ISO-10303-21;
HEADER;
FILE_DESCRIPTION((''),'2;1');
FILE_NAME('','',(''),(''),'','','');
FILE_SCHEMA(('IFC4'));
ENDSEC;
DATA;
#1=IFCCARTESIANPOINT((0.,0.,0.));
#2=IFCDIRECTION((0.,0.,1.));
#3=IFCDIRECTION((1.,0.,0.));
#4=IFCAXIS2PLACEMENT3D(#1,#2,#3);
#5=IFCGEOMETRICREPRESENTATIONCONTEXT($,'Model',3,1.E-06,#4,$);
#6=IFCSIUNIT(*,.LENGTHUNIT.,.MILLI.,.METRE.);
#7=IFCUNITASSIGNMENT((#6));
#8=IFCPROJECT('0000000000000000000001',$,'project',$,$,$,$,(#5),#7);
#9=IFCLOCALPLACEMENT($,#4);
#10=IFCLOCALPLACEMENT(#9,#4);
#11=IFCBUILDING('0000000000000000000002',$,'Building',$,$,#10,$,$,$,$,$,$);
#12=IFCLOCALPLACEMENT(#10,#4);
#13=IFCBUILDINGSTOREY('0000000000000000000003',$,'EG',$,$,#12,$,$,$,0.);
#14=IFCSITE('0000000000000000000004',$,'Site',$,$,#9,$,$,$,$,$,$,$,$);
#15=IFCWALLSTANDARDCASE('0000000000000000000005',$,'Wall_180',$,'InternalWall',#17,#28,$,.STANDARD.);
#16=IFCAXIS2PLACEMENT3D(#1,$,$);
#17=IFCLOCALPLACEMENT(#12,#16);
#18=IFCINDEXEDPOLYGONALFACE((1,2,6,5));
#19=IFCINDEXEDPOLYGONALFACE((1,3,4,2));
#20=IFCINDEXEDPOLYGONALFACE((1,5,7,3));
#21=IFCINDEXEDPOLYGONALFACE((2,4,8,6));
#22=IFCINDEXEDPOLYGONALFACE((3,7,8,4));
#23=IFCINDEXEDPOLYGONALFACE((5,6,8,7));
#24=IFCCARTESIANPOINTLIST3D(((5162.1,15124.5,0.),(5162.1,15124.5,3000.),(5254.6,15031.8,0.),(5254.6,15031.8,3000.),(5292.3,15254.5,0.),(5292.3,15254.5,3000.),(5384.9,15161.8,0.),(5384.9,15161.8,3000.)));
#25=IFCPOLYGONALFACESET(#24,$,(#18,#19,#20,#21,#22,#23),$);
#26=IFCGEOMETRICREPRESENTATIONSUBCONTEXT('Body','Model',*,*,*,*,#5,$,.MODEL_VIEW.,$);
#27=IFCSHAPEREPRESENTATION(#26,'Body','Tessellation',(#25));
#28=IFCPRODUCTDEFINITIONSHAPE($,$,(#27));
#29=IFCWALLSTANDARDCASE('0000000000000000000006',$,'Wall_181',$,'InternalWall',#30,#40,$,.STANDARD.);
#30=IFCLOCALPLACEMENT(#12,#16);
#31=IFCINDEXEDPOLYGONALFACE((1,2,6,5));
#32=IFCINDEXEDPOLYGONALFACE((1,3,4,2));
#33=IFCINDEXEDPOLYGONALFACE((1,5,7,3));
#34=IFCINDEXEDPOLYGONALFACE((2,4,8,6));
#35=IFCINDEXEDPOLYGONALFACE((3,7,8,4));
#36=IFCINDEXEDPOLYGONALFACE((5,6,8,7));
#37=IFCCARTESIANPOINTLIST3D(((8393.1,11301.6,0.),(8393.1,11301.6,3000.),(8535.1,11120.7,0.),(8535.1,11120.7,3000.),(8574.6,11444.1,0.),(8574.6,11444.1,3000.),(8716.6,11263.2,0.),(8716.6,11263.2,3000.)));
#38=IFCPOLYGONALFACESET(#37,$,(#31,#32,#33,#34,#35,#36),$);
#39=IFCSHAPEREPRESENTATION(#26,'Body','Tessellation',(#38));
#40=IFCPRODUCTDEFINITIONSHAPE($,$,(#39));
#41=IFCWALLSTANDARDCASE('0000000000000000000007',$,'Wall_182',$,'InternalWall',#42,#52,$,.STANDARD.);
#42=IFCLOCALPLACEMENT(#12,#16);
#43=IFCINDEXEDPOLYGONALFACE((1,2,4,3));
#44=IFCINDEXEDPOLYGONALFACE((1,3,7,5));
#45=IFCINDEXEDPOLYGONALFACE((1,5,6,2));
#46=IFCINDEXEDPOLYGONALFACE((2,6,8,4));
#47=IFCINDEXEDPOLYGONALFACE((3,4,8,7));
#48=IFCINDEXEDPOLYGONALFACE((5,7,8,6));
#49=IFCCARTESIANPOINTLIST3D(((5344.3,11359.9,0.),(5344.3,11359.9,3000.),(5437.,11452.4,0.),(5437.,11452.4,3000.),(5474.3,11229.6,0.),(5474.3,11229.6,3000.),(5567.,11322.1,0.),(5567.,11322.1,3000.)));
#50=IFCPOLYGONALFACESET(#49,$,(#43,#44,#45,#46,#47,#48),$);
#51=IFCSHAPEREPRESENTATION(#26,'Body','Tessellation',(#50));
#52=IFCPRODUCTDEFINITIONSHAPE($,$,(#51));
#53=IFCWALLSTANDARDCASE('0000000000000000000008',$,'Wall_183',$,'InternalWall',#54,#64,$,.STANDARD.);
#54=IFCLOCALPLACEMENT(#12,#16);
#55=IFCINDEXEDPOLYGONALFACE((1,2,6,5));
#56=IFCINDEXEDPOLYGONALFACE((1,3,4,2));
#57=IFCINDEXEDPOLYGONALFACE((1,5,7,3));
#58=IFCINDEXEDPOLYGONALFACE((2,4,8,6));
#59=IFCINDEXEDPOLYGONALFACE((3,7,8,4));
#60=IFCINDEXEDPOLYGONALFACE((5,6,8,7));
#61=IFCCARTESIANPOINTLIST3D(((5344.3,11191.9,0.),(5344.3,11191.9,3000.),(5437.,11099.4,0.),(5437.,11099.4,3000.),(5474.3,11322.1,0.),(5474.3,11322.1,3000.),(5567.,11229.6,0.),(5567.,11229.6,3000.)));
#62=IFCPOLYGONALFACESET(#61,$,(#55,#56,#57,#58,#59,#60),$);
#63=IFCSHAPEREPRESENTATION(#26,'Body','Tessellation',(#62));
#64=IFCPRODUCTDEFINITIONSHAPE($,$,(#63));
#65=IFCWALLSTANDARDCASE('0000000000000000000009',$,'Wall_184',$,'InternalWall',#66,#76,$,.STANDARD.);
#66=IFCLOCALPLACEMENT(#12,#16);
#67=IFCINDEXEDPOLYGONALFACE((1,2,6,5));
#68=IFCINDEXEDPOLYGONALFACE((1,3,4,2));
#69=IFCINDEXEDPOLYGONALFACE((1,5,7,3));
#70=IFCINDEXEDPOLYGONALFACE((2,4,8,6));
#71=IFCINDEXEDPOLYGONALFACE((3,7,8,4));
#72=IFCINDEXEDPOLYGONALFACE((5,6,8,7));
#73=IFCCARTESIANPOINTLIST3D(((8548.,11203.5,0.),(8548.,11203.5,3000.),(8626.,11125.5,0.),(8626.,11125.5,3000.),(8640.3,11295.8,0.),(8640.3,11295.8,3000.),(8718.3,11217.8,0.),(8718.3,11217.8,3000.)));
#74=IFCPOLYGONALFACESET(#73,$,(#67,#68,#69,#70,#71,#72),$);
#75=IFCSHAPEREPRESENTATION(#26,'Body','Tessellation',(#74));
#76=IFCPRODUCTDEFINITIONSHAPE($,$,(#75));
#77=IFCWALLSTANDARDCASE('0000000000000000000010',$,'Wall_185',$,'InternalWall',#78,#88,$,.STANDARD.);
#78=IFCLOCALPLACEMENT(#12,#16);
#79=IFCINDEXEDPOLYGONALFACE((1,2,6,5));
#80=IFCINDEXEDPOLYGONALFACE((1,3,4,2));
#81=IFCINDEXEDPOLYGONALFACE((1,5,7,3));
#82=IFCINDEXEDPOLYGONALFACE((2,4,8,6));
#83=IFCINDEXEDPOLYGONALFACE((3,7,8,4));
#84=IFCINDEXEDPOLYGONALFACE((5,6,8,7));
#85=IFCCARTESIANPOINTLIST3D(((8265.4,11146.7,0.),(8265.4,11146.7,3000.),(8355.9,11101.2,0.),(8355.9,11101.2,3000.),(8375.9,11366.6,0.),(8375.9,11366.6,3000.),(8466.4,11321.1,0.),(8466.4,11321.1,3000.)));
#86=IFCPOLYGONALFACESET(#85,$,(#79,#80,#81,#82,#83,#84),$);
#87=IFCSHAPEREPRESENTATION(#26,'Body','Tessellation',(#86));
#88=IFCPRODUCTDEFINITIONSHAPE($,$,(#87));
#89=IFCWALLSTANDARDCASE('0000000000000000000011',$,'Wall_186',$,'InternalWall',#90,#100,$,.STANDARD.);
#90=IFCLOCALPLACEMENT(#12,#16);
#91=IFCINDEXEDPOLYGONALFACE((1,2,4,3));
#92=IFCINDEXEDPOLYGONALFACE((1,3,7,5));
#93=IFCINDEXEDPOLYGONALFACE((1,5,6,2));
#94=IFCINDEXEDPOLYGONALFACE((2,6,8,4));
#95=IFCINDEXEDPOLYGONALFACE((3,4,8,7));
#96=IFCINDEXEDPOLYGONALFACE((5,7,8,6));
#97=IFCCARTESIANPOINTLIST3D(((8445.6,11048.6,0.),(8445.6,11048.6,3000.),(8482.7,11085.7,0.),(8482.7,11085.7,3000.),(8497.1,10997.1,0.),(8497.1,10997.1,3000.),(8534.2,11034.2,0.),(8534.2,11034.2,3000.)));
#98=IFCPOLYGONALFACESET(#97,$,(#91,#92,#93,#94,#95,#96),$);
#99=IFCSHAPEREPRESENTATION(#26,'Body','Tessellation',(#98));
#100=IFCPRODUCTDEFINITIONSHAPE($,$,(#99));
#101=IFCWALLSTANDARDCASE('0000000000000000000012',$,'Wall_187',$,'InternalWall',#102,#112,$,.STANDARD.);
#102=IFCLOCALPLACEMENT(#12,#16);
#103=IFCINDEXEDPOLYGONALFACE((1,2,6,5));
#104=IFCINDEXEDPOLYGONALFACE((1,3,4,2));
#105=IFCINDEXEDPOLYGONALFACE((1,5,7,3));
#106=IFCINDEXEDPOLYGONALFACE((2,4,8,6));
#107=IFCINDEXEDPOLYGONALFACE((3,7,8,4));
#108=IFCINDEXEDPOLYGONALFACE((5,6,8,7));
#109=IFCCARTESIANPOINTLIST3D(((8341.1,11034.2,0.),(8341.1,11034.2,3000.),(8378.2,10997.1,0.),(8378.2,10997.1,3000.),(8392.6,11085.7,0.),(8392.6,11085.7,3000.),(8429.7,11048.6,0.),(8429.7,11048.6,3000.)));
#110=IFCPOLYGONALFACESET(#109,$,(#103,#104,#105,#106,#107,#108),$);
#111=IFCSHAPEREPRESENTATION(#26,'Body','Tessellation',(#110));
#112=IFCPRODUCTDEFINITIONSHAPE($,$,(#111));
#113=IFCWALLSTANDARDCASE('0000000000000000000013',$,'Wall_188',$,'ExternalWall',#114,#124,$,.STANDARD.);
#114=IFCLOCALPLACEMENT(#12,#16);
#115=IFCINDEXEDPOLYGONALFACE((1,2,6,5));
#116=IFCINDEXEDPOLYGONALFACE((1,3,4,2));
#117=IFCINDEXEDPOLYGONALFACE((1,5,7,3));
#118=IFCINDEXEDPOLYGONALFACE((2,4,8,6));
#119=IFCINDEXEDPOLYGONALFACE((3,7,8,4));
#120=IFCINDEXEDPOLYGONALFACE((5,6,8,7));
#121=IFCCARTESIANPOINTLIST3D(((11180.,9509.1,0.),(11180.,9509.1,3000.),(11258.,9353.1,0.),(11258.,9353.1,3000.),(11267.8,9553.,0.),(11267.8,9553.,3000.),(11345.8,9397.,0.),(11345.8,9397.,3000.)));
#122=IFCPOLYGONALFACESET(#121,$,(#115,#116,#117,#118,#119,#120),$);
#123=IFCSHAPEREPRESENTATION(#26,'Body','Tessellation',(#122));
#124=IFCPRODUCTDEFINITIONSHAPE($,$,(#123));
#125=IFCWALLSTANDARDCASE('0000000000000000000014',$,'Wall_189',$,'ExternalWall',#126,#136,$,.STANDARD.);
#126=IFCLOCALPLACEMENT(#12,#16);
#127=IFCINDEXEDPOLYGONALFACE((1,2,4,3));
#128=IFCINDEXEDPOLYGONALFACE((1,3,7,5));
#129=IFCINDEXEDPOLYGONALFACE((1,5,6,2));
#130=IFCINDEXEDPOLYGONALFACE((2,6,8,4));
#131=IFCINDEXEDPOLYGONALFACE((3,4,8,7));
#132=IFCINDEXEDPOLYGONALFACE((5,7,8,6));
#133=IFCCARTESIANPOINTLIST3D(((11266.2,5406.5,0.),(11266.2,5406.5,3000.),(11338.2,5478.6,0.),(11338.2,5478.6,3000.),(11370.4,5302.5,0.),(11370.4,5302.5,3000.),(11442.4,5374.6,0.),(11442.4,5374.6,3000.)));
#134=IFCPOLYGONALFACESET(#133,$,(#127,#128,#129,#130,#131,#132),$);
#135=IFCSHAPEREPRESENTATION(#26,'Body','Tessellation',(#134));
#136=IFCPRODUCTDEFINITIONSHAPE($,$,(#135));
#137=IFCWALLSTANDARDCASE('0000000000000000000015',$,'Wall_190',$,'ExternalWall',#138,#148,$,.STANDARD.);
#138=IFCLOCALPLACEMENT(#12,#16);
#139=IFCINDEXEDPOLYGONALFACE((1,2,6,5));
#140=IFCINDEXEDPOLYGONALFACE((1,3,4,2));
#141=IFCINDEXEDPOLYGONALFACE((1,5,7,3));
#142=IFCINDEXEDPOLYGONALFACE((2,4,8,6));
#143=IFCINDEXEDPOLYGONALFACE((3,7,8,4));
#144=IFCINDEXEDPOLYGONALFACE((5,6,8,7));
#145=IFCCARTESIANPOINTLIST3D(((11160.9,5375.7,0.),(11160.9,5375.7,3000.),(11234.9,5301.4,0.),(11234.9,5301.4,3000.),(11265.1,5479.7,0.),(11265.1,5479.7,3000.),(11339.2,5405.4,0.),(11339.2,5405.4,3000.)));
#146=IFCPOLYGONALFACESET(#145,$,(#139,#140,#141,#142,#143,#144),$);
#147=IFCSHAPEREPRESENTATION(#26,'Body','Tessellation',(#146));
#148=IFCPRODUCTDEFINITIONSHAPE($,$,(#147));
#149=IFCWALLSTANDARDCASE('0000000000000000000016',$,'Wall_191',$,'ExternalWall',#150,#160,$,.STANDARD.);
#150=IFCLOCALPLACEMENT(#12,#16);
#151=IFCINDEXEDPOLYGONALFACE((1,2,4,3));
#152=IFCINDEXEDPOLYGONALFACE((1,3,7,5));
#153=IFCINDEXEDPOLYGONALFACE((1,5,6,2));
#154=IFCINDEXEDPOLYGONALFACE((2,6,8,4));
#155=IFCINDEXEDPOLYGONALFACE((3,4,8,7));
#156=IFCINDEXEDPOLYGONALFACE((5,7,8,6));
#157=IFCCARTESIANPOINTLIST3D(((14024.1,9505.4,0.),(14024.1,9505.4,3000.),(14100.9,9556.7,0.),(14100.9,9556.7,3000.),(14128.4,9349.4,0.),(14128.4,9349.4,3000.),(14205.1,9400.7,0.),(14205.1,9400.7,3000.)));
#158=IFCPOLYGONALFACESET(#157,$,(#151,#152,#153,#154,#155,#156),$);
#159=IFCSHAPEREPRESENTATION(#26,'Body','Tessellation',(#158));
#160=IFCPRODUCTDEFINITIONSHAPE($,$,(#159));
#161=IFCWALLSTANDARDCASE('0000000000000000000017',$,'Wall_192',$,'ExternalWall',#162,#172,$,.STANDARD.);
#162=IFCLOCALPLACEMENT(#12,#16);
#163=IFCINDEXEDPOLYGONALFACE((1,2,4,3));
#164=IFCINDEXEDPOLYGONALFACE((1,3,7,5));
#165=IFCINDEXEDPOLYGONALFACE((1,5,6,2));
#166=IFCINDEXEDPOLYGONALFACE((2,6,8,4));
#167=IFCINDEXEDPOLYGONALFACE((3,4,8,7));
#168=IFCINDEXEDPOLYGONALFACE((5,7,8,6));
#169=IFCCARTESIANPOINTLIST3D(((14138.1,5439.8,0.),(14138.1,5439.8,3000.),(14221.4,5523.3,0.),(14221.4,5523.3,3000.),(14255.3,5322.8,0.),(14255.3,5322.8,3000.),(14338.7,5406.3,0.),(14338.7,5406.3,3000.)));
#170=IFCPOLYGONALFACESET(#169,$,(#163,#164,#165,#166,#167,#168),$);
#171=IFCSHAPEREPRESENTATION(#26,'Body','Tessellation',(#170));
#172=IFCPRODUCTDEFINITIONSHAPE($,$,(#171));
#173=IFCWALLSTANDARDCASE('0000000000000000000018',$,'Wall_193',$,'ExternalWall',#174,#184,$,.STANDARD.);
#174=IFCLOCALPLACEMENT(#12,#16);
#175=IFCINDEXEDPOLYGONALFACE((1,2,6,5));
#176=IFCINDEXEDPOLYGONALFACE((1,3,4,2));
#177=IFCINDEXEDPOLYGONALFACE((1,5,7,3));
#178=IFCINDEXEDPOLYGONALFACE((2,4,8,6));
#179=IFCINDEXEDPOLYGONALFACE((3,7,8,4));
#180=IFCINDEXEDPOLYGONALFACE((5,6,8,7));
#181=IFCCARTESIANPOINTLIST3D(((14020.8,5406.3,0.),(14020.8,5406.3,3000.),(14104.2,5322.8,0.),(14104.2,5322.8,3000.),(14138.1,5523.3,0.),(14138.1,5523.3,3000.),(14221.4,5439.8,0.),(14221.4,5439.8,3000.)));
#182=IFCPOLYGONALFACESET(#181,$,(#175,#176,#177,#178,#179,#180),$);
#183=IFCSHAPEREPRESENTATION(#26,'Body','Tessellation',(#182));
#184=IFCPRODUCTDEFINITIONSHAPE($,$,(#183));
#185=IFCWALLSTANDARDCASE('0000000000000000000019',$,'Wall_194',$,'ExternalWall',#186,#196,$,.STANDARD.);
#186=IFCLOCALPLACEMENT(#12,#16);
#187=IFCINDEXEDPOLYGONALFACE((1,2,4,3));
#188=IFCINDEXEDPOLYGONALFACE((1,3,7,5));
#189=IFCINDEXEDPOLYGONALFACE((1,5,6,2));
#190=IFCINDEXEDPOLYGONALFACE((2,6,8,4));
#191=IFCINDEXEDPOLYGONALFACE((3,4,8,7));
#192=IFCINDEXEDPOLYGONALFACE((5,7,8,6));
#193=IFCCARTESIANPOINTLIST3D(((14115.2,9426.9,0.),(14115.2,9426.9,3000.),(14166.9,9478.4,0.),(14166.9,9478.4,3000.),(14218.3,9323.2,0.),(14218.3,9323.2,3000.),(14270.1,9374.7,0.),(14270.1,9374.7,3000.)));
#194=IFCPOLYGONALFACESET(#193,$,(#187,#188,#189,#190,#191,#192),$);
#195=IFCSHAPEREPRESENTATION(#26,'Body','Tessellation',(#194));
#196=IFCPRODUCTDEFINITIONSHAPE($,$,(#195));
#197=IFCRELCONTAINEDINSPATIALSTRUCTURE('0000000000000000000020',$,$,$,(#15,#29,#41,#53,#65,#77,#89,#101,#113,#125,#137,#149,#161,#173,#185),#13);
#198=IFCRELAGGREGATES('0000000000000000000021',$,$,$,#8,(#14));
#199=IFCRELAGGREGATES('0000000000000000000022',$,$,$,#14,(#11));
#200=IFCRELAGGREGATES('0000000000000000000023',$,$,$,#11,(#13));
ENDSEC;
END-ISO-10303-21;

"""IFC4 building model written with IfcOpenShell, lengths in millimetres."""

from ifc_helpers import new_model, si_unit, frame, origin_with_axes, place, context, subcontext, project, spatial, rectangle, extrude, element, save


model = new_model("IFC4")

# Units and contexts
model_context = context("Model", 3, precision=1e-06, world=origin_with_axes())
body_context = subcontext(model_context, "Body", "Model", "MODEL_VIEW")
ifc_project = project(units=[si_unit("LENGTHUNIT", "METRE", prefix="MILLI")], contexts=[model_context])

# Site, building, storey
site_placement = place(None, origin_with_axes())
site = spatial("IfcSite", under=ifc_project, at=site_placement, Name="Site")
building_placement = place(site_placement, origin_with_axes())
building = spatial("IfcBuilding", under=site, at=building_placement, Name="Building")
storey_placement = place(building_placement, origin_with_axes())
storey = spatial("IfcBuildingStorey", under=building, at=storey_placement, Name="EG", Elevation=0.0)

# Walls
wall_1_placement = place(storey_placement, origin_with_axes())
element("IfcWallStandardCase", 1, at=wall_1_placement, inside=storey, Name="Wall_180", ObjectType="InternalWall", PredefinedType="STANDARD", context=body_context, shape_type="SweptSolid", body=[
    extrude(rectangle(XDim=184.0, YDim=131.0), frame((5273.5, 15143.1, 0.0), z_axis=(0.0, 0.0, 1.0), x_axis=(-0.707786, -0.706427, 0.0)), (0.0, 0.0, 1.0), 3000.0),
])
wall_2_placement = place(storey_placement, origin_with_axes())
element("IfcWallStandardCase", 2, at=wall_2_placement, inside=storey, Name="Wall_181", ObjectType="InternalWall", PredefinedType="STANDARD", context=body_context, shape_type="SweptSolid", body=[
    extrude(rectangle(XDim=230.8, YDim=230.0), frame((8554.9, 11282.4, 0.0), z_axis=(0.0, 0.0, 1.0), x_axis=(0.786544, 0.617534, 0.0)), (0.0, 0.0, 1.0), 3000.0),
])
wall_3_placement = place(storey_placement, origin_with_axes())
element("IfcWallStandardCase", 3, at=wall_3_placement, inside=storey, Name="Wall_182", ObjectType="InternalWall", PredefinedType="STANDARD", context=body_context, shape_type="SweptSolid", body=[
    extrude(rectangle(XDim=184.0, YDim=131.0), frame((5455.6, 11341.0, 0.0), z_axis=(0.0, 0.0, 1.0), x_axis=(-0.706427, 0.707786, 0.0)), (0.0, 0.0, 1.0), 3000.0),
])
wall_4_placement = place(storey_placement, origin_with_axes())
element("IfcWallStandardCase", 4, at=wall_4_placement, inside=storey, Name="Wall_183", ObjectType="InternalWall", PredefinedType="STANDARD", context=body_context, shape_type="SweptSolid", body=[
    extrude(rectangle(XDim=184.0, YDim=131.0), frame((5455.6, 11210.8, 0.0), z_axis=(0.0, 0.0, 1.0), x_axis=(-0.706427, -0.707786, 0.0)), (0.0, 0.0, 1.0), 3000.0),
])
wall_5_placement = place(storey_placement, origin_with_axes())
element("IfcWallStandardCase", 5, at=wall_5_placement, inside=storey, Name="Wall_184", ObjectType="InternalWall", PredefinedType="STANDARD", context=body_context, shape_type="SweptSolid", body=[
    extrude(rectangle(XDim=110.3, YDim=130.5), frame((8633.1, 11210.6, 0.0), z_axis=(0.0, 0.0, 1.0), x_axis=(0.707107, -0.707107, 0.0)), (0.0, 0.0, 1.0), 3000.0),
])
wall_6_placement = place(storey_placement, origin_with_axes())
element("IfcWallStandardCase", 6, at=wall_6_placement, inside=storey, Name="Wall_185", ObjectType="InternalWall", PredefinedType="STANDARD", context=body_context, shape_type="SweptSolid", body=[
    extrude(rectangle(XDim=101.3, YDim=246.1), frame((8365.9, 11233.9, 0.0), z_axis=(0.0, 0.0, 1.0), x_axis=(0.893438, -0.449187, 0.0)), (0.0, 0.0, 1.0), 3000.0),
])
wall_7_placement = place(storey_placement, origin_with_axes())
element("IfcWallStandardCase", 7, at=wall_7_placement, inside=storey, Name="Wall_186", ObjectType="InternalWall", PredefinedType="STANDARD", context=body_context, shape_type="SweptSolid", body=[
    extrude(rectangle(XDim=72.8, YDim=52.5), frame((8489.9, 11041.4, 0.0), z_axis=(0.0, 0.0, 1.0), x_axis=(0.707107, -0.707107, 0.0)), (0.0, 0.0, 1.0), 3000.0),
])
wall_8_placement = place(storey_placement, origin_with_axes())
element("IfcWallStandardCase", 8, at=wall_8_placement, inside=storey, Name="Wall_187", ObjectType="InternalWall", PredefinedType="STANDARD", context=body_context, shape_type="SweptSolid", body=[
    extrude(rectangle(XDim=72.8, YDim=52.5), frame((8385.4, 11041.4, 0.0), z_axis=(0.0, 0.0, 1.0), x_axis=(-0.707107, -0.707107, 0.0)), (0.0, 0.0, 1.0), 3000.0),
])
wall_9_placement = place(storey_placement, origin_with_axes())
element("IfcWallStandardCase", 9, at=wall_9_placement, inside=storey, Name="Wall_188", ObjectType="ExternalWall", PredefinedType="STANDARD", context=body_context, shape_type="SweptSolid", body=[
    extrude(rectangle(XDim=174.4, YDim=98.2), frame((11262.9, 9453.0, 0.0), z_axis=(0.0, 0.0, 1.0), x_axis=(-0.447214, 0.894427, 0.0)), (0.0, 0.0, 1.0), 3000.0),
])
wall_10_placement = place(storey_placement, origin_with_axes())
element("IfcWallStandardCase", 10, at=wall_10_placement, inside=storey, Name="Wall_189", ObjectType="ExternalWall", PredefinedType="STANDARD", context=body_context, shape_type="SweptSolid", body=[
    extrude(rectangle(XDim=147.3, YDim=101.9), frame((11354.3, 5390.5, 0.0), z_axis=(0.0, 0.0, 1.0), x_axis=(0.707955, -0.706257, 0.0)), (0.0, 0.0, 1.0), 3000.0),
])
wall_11_placement = place(storey_placement, origin_with_axes())
element("IfcWallStandardCase", 11, at=wall_11_placement, inside=storey, Name="Wall_190", ObjectType="ExternalWall", PredefinedType="STANDARD", context=body_context, shape_type="SweptSolid", body=[
    extrude(rectangle(XDim=147.3, YDim=104.8), frame((11250.0, 5390.5, 0.0), z_axis=(0.0, 0.0, 1.0), x_axis=(-0.707955, -0.706257, 0.0)), (0.0, 0.0, 1.0), 3000.0),
])
wall_12_placement = place(storey_placement, origin_with_axes())
element("IfcWallStandardCase", 12, at=wall_12_placement, inside=storey, Name="Wall_191", ObjectType="ExternalWall", PredefinedType="STANDARD", context=body_context, shape_type="SweptSolid", body=[
    extrude(rectangle(XDim=187.6, YDim=92.4), frame((14114.6, 9453.1, 0.0), z_axis=(0.0, 0.0, 1.0), x_axis=(-0.555622, 0.831435, 0.0)), (0.0, 0.0, 1.0), 3000.0),
])
wall_13_placement = place(storey_placement, origin_with_axes())
element("IfcWallStandardCase", 13, at=wall_13_placement, inside=storey, Name="Wall_192", ObjectType="ExternalWall", PredefinedType="STANDARD", context=body_context, shape_type="SweptSolid", body=[
    extrude(rectangle(XDim=165.6, YDim=118.0), frame((14238.4, 5423.1, 0.0), z_axis=(0.0, 0.0, 1.0), x_axis=(0.707861, -0.706352, 0.0)), (0.0, 0.0, 1.0), 3000.0),
])
wall_14_placement = place(storey_placement, origin_with_axes())
element("IfcWallStandardCase", 14, at=wall_14_placement, inside=storey, Name="Wall_193", ObjectType="ExternalWall", PredefinedType="STANDARD", context=body_context, shape_type="SweptSolid", body=[
    extrude(rectangle(XDim=165.6, YDim=118.0), frame((14121.1, 5423.1, 0.0), z_axis=(0.0, 0.0, 1.0), x_axis=(-0.707861, -0.706352, 0.0)), (0.0, 0.0, 1.0), 3000.0),
])
wall_15_placement = place(storey_placement, origin_with_axes())
element("IfcWallStandardCase", 15, at=wall_15_placement, inside=storey, Name="Wall_194", ObjectType="ExternalWall", PredefinedType="STANDARD", context=body_context, shape_type="SweptSolid", body=[
    extrude(rectangle(XDim=73.0, YDim=146.3), frame((14192.6, 9400.8, 0.0), z_axis=(0.0, 0.0, 1.0), x_axis=(0.708817, 0.705393, 0.0)), (0.0, 0.0, 1.0), 3000.0),
])

save(model, "model.ifc")
